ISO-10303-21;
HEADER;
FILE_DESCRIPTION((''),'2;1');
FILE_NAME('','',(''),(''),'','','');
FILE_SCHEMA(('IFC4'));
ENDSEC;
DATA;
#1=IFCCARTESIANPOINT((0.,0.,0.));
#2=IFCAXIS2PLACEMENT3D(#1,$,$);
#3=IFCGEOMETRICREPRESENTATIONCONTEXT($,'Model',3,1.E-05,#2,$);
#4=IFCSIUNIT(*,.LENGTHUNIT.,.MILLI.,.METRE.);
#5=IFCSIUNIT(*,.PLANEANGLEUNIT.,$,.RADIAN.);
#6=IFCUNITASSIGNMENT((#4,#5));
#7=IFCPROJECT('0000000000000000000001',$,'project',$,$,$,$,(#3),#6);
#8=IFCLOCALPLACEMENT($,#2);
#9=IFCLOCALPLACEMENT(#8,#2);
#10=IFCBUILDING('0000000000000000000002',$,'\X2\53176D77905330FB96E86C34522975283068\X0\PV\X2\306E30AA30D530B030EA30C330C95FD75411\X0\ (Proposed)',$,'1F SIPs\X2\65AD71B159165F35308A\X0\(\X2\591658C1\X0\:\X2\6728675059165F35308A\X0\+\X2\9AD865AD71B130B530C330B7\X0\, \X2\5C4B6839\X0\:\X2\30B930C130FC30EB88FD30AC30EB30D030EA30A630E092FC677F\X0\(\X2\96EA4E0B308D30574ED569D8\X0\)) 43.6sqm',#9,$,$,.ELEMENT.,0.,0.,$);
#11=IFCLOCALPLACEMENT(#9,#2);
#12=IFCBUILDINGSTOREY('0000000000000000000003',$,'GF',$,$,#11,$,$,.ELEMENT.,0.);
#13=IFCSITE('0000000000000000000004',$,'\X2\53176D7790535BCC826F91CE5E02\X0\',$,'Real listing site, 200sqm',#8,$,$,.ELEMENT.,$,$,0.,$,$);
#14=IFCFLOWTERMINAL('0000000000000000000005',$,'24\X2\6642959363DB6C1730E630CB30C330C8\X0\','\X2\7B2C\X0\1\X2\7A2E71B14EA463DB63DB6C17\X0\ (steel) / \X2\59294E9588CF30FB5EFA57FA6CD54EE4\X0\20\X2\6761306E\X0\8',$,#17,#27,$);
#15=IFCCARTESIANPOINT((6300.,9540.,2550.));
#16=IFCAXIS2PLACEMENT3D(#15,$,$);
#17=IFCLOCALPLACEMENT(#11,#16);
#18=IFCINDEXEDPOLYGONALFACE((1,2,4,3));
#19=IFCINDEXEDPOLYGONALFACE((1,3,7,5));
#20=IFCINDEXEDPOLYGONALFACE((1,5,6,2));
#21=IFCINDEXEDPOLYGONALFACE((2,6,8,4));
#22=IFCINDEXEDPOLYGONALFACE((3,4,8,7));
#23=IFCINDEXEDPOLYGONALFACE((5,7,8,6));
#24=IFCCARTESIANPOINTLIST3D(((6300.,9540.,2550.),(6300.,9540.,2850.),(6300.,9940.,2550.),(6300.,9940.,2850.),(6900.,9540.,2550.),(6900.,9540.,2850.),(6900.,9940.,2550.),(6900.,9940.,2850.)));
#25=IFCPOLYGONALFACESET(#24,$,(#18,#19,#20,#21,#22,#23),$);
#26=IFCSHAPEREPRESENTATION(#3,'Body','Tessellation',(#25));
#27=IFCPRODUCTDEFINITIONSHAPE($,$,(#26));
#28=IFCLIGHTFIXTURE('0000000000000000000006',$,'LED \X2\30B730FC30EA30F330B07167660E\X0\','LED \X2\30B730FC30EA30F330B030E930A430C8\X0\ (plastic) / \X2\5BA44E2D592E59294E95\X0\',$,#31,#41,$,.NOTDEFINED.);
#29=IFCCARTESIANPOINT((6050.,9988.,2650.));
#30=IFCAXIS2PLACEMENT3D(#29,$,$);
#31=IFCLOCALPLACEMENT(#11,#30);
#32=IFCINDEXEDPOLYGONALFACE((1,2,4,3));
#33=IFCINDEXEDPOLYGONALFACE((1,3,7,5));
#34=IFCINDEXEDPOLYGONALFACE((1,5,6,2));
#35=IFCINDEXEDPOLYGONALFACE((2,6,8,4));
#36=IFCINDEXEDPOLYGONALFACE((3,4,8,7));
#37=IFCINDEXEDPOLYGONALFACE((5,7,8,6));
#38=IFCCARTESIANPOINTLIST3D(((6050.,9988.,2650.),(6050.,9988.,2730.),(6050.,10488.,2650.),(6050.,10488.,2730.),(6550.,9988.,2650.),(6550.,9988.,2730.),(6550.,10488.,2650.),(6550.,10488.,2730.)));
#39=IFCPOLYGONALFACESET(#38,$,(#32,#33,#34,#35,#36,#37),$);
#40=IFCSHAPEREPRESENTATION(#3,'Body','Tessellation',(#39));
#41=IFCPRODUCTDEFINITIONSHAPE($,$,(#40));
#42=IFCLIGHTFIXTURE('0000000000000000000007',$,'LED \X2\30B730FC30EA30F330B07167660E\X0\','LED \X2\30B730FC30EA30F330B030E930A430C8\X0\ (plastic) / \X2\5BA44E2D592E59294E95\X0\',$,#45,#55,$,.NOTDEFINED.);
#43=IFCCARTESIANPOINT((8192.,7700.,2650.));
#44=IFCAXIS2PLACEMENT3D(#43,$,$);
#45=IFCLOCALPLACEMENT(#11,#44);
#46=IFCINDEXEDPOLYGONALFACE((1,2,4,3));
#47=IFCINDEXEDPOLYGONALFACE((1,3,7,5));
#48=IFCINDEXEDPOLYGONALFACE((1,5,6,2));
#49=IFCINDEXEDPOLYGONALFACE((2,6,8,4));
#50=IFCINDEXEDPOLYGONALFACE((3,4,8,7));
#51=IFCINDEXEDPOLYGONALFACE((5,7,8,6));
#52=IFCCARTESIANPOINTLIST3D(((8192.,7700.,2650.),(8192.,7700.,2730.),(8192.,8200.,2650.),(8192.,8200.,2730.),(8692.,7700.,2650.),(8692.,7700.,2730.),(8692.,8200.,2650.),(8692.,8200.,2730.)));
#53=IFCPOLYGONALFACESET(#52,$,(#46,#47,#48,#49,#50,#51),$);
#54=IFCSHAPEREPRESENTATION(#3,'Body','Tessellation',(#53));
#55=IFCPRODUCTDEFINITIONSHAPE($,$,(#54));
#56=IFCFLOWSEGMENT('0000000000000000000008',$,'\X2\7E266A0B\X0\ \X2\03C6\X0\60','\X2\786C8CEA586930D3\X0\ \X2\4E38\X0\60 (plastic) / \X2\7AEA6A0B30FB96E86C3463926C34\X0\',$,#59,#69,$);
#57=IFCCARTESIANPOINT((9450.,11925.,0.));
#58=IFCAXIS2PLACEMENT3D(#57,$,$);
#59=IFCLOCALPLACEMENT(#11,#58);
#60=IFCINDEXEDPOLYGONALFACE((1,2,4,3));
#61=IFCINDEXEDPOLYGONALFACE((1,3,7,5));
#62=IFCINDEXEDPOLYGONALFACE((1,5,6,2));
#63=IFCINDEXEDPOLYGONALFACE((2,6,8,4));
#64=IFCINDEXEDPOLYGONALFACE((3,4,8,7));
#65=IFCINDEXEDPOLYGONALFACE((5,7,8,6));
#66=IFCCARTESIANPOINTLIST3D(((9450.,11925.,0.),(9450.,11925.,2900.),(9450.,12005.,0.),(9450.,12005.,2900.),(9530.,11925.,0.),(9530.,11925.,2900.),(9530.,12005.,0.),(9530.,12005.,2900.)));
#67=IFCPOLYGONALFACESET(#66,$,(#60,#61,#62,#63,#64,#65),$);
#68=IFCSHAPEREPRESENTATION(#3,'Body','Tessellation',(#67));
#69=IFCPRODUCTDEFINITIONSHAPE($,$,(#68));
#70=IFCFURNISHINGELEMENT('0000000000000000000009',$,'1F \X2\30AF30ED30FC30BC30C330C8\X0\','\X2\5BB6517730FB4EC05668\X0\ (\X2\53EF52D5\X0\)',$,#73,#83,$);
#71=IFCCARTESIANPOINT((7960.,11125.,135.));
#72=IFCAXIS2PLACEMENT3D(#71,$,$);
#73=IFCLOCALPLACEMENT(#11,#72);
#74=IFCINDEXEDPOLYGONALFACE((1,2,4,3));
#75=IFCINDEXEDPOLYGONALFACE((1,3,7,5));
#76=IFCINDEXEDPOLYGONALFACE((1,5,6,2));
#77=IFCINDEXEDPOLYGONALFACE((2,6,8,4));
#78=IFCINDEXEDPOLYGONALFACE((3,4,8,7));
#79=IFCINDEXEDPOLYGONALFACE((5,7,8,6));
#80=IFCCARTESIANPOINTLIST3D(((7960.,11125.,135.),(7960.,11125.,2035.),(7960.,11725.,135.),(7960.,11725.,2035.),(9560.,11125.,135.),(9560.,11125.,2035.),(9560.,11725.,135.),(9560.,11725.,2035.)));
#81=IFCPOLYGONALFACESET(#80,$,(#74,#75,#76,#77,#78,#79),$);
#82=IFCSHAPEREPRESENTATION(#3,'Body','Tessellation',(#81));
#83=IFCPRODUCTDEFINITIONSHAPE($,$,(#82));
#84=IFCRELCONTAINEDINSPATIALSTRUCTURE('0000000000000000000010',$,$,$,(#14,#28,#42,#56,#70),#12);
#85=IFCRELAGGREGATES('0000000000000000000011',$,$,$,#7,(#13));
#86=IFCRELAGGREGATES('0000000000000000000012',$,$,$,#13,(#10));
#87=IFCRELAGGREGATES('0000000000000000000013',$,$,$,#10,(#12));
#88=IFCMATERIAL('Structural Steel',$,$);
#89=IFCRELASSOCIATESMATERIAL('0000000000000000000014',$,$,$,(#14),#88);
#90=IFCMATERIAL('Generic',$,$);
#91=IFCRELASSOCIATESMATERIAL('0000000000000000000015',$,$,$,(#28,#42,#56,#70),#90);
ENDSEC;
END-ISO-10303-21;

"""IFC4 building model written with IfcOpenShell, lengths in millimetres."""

from ifc_helpers import new_model, si_unit, frame, frame_2d, origin, place, context, project, spatial, rectangle, extrude, material, element, save


model = new_model("IFC4")

# Units and contexts
model_context = context("Model", 3, precision=1e-05, world=origin())
ifc_project = project(units=[si_unit("LENGTHUNIT", "METRE", prefix="MILLI"), si_unit("PLANEANGLEUNIT", "RADIAN")], contexts=[model_context])

# Site, building, storey
site_placement = place(None, origin())
site = spatial("IfcSite", under=ifc_project, at=site_placement, Name="北海道富良野市", ObjectType="Real listing site, 200sqm", CompositionType="ELEMENT", RefElevation=0.0)
building_placement = place(site_placement, origin())
building = spatial("IfcBuilding", under=site, at=building_placement, Name="北海道・雨水利用とPVのオフグリッド志向 (Proposed)", ObjectType="1F SIPs断熱外張り(外壁:木材外張り+高断熱サッシ, 屋根:スチール製ガルバリウム鋼板(雪下ろし仕様)) 43.6sqm", CompositionType="ELEMENT", ElevationOfRefHeight=0.0, ElevationOfTerrain=0.0)
storey_placement = place(building_placement, origin())
storey = spatial("IfcBuildingStorey", under=building, at=storey_placement, Name="GF", CompositionType="ELEMENT", Elevation=0.0)

# Shared definitions
ifc_material_1 = material(Name="Generic")

# Flow terminal
ifc_material_2 = material(Name="Structural Steel")
flow_terminal_placement = place(storey_placement, frame((6300.0, 9540.0, 2550.0)))
element("IfcFlowTerminal", 1, at=flow_terminal_placement, inside=storey, material=ifc_material_2, Name="24時間換気ユニット", Description="第1種熱交換換気 (steel) / 天井裏・建基法令20条の8", context=model_context, shape_type="SweptSolid", body=[
    extrude(rectangle(XDim=600.0, YDim=400.0, at=frame_2d((300.0, 200.0))), frame((6300.0, 9540.0, 2550.0)), (0.0, 0.0, 1.0), 300.0),
])

# Light fixtures
light_fixture_1_placement = place(storey_placement, frame((6050.0, 9988.0, 2650.0)))
element("IfcLightFixture", 2, at=light_fixture_1_placement, inside=storey, material=ifc_material_1, Name="LED シーリング照明", Description="LED シーリングライト (plastic) / 室中央天井", PredefinedType="NOTDEFINED", context=model_context, shape_type="SweptSolid", body=[
    extrude(rectangle(XDim=500.0, YDim=500.0, at=frame_2d((250.0, 250.0))), frame((6050.0, 9988.0, 2650.0)), (0.0, 0.0, 1.0), 80.0),
])
light_fixture_2_placement = place(storey_placement, frame((8192.0, 7700.0, 2650.0)))
element("IfcLightFixture", 3, at=light_fixture_2_placement, inside=storey, material=ifc_material_1, Name="LED シーリング照明", Description="LED シーリングライト (plastic) / 室中央天井", PredefinedType="NOTDEFINED", context=model_context, shape_type="SweptSolid", body=[
    extrude(rectangle(XDim=500.0, YDim=500.0, at=frame_2d((250.0, 250.0))), frame((8192.0, 7700.0, 2650.0)), (0.0, 0.0, 1.0), 80.0),
])

# Flow segment
flow_segment_placement = place(storey_placement, frame((9450.0, 11925.0, 0.0)))
element("IfcFlowSegment", 4, at=flow_segment_placement, inside=storey, material=ifc_material_1, Name="縦樋 φ60", Description="硬質塩ビ 丸60 (plastic) / 竪樋・雨水排水", context=model_context, shape_type="SweptSolid", body=[
    extrude(rectangle(XDim=80.0, YDim=80.0, at=frame_2d((40.0, 40.0))), frame((9450.0, 11925.0, 0.0)), (0.0, 0.0, 1.0), 2900.0),
])

# Furnishing element
furnishing_placement = place(storey_placement, frame((7960.0, 11125.0, 135.0)))
element("IfcFurnishingElement", 5, at=furnishing_placement, inside=storey, material=ifc_material_1, Name="1F クローゼット", Description="家具・什器 (可動)", context=model_context, shape_type="SweptSolid", body=[
    extrude(rectangle(XDim=1600.0, YDim=600.0, at=frame_2d((800.0, 300.0))), frame((7960.0, 11125.0, 135.0)), (0.0, 0.0, 1.0), 1900.0),
])

save(model, "model.ifc")
